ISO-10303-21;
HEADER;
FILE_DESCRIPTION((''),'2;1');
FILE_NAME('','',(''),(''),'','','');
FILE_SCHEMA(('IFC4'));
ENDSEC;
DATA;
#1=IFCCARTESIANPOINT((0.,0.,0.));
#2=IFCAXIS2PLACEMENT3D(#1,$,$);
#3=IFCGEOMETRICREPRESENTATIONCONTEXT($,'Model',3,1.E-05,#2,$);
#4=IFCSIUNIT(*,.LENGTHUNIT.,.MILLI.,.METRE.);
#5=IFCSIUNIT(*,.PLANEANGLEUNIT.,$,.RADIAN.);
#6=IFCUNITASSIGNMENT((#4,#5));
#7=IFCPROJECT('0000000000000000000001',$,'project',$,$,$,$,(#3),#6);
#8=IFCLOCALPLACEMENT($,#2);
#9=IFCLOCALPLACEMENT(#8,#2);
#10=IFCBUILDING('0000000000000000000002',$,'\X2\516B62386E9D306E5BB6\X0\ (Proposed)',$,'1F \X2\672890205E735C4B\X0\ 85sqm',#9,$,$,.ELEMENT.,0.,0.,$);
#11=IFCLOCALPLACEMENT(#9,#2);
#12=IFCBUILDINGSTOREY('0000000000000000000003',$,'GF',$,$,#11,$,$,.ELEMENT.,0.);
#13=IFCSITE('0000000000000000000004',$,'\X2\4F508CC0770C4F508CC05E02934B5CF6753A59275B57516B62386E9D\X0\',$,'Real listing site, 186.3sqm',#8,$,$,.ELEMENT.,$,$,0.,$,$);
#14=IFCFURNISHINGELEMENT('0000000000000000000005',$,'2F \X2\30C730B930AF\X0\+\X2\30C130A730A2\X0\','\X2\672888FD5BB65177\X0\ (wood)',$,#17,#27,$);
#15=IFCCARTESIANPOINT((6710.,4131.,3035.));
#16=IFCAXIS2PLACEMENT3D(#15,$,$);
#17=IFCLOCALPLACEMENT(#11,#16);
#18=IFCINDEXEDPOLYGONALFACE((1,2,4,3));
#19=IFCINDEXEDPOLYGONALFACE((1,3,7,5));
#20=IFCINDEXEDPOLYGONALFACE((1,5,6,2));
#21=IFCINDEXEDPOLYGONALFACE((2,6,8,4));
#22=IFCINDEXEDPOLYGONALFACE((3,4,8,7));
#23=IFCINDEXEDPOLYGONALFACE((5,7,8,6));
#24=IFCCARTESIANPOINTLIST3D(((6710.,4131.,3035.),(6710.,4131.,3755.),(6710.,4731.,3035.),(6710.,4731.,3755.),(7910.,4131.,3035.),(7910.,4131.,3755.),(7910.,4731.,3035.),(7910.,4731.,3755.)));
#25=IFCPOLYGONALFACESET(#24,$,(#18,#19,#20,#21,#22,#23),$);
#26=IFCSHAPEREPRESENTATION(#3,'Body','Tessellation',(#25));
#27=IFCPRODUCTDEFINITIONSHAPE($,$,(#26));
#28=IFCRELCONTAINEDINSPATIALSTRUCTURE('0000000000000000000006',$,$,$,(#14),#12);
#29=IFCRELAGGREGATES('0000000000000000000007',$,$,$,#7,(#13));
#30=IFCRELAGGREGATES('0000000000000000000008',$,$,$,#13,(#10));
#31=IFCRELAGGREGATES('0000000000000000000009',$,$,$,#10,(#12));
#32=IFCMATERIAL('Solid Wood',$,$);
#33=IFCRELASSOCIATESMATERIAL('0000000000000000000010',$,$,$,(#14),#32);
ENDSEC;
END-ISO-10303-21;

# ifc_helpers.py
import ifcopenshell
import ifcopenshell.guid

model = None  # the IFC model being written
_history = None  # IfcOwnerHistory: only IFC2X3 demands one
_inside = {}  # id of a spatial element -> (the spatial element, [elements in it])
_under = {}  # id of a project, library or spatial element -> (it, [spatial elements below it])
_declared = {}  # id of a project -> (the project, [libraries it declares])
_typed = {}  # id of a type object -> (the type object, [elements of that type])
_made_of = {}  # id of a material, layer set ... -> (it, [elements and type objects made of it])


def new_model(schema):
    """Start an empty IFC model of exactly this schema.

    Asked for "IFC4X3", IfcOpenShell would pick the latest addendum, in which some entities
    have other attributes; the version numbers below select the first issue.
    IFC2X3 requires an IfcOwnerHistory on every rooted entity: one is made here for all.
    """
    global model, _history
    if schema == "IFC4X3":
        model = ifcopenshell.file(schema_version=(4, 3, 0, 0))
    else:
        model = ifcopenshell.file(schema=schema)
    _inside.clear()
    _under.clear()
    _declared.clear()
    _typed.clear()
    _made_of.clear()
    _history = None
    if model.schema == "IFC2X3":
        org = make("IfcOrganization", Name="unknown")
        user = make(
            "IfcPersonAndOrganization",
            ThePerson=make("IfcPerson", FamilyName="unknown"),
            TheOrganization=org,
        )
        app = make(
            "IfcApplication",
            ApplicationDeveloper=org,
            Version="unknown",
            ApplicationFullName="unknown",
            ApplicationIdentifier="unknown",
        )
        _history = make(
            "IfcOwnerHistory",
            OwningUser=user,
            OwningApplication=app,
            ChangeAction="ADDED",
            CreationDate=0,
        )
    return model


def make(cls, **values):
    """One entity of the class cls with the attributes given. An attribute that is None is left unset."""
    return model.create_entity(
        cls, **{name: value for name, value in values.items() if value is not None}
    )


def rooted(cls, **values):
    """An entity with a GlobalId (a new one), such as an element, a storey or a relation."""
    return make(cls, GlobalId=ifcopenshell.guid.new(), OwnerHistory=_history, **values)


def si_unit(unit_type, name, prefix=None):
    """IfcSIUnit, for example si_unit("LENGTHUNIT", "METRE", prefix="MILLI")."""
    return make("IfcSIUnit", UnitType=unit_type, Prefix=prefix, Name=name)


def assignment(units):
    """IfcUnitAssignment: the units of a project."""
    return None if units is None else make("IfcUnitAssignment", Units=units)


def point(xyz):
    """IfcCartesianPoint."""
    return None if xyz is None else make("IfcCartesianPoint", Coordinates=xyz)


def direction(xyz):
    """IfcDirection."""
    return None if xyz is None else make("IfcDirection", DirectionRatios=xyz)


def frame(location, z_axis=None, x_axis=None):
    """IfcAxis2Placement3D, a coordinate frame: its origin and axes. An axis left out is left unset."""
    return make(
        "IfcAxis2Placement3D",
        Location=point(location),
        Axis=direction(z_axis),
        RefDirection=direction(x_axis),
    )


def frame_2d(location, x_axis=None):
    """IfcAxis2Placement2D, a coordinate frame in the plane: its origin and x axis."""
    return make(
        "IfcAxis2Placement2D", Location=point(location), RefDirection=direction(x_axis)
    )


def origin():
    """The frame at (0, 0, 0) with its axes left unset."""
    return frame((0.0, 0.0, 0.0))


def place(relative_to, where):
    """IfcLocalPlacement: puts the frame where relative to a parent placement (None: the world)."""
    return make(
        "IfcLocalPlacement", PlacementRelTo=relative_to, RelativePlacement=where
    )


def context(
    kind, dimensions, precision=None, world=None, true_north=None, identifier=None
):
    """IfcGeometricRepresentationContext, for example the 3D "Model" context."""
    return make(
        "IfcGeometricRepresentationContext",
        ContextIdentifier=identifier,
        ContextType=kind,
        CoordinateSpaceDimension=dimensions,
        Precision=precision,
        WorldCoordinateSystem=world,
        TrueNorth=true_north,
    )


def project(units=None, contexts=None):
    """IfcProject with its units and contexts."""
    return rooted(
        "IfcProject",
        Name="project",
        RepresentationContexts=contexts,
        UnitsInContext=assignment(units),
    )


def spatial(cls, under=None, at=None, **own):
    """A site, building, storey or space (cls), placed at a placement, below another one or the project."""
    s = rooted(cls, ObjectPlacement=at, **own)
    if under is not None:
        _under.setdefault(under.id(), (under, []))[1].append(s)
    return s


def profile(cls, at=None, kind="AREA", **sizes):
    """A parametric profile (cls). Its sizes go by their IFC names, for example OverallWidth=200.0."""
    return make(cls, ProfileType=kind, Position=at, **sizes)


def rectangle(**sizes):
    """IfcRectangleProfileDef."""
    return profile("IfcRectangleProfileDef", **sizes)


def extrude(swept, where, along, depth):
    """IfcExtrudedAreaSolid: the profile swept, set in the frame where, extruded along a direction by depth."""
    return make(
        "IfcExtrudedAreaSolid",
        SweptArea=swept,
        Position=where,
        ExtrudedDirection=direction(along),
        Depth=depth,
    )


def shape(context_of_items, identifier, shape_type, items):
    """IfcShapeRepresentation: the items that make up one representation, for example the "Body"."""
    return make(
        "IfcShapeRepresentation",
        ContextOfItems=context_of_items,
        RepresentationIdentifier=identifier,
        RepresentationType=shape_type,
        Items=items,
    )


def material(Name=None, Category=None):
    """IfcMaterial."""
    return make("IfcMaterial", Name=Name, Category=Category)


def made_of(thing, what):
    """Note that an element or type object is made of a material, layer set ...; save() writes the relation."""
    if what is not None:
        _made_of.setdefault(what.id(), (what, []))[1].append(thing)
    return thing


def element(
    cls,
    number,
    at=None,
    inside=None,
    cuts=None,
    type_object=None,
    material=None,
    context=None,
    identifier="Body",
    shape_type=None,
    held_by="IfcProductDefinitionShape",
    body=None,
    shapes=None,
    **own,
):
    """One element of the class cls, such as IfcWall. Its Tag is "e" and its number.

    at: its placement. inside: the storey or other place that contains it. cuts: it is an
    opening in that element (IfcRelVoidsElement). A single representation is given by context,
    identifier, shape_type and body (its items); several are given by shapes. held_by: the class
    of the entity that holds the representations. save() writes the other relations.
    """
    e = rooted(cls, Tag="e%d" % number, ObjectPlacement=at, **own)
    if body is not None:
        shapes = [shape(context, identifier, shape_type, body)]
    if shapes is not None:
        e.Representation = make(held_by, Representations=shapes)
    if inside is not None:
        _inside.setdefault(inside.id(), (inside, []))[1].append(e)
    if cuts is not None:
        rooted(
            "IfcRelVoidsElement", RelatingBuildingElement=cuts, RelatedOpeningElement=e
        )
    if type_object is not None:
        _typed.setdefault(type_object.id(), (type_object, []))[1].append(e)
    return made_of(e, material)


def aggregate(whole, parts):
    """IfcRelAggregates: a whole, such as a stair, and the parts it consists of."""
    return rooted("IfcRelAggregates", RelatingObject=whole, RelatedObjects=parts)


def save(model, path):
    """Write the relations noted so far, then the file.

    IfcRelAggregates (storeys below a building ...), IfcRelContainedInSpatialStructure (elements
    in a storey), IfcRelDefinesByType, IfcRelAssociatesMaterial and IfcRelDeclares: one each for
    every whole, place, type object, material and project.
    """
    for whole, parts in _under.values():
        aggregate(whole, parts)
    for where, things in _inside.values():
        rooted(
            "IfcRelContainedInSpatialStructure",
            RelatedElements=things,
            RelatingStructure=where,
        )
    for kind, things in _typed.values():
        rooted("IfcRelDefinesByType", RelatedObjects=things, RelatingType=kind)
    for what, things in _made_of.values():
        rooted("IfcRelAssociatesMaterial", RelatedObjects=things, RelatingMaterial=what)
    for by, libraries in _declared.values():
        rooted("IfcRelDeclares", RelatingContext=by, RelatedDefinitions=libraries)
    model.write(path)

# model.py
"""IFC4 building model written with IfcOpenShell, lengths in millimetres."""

from ifc_helpers import new_model, si_unit, frame, frame_2d, origin, place, context, project, spatial, rectangle, extrude, material, element, save


model = new_model("IFC4")

# Units and contexts
model_context = context("Model", 3, precision=1e-05, world=origin())
ifc_project = project(units=[si_unit("LENGTHUNIT", "METRE", prefix="MILLI"), si_unit("PLANEANGLEUNIT", "RADIAN")], contexts=[model_context])

# Site, building, storey
site_placement = place(None, origin())
site = spatial("IfcSite", under=ifc_project, at=site_placement, Name="佐賀県佐賀市鍋島町大字八戸溝", ObjectType="Real listing site, 186.3sqm", CompositionType="ELEMENT", RefElevation=0.0)
building_placement = place(site_placement, origin())
building = spatial("IfcBuilding", under=site, at=building_placement, Name="八戸溝の家 (Proposed)", ObjectType="1F 木造平屋 85sqm", CompositionType="ELEMENT", ElevationOfRefHeight=0.0, ElevationOfTerrain=0.0)
storey_placement = place(building_placement, origin())
storey = spatial("IfcBuildingStorey", under=building, at=storey_placement, Name="GF", CompositionType="ELEMENT", Elevation=0.0)

# Shared definitions
ifc_material_1 = material(Name="Solid Wood")

# Furnishing element
furnishing_1_placement = place(storey_placement, frame((6710.0, 4131.0, 3035.0)))
element("IfcFurnishingElement", 1, at=furnishing_1_placement, inside=storey, material=ifc_material_1, Name="2F デスク+チェア", Description="木製家具 (wood)", context=model_context, shape_type="SweptSolid", body=[
    extrude(rectangle(XDim=1200.0, YDim=600.0, at=frame_2d((600.0, 300.0))), frame((6710.0, 4131.0, 3035.0)), (0.0, 0.0, 1.0), 720.0),
])

save(model, "model.ifc")
